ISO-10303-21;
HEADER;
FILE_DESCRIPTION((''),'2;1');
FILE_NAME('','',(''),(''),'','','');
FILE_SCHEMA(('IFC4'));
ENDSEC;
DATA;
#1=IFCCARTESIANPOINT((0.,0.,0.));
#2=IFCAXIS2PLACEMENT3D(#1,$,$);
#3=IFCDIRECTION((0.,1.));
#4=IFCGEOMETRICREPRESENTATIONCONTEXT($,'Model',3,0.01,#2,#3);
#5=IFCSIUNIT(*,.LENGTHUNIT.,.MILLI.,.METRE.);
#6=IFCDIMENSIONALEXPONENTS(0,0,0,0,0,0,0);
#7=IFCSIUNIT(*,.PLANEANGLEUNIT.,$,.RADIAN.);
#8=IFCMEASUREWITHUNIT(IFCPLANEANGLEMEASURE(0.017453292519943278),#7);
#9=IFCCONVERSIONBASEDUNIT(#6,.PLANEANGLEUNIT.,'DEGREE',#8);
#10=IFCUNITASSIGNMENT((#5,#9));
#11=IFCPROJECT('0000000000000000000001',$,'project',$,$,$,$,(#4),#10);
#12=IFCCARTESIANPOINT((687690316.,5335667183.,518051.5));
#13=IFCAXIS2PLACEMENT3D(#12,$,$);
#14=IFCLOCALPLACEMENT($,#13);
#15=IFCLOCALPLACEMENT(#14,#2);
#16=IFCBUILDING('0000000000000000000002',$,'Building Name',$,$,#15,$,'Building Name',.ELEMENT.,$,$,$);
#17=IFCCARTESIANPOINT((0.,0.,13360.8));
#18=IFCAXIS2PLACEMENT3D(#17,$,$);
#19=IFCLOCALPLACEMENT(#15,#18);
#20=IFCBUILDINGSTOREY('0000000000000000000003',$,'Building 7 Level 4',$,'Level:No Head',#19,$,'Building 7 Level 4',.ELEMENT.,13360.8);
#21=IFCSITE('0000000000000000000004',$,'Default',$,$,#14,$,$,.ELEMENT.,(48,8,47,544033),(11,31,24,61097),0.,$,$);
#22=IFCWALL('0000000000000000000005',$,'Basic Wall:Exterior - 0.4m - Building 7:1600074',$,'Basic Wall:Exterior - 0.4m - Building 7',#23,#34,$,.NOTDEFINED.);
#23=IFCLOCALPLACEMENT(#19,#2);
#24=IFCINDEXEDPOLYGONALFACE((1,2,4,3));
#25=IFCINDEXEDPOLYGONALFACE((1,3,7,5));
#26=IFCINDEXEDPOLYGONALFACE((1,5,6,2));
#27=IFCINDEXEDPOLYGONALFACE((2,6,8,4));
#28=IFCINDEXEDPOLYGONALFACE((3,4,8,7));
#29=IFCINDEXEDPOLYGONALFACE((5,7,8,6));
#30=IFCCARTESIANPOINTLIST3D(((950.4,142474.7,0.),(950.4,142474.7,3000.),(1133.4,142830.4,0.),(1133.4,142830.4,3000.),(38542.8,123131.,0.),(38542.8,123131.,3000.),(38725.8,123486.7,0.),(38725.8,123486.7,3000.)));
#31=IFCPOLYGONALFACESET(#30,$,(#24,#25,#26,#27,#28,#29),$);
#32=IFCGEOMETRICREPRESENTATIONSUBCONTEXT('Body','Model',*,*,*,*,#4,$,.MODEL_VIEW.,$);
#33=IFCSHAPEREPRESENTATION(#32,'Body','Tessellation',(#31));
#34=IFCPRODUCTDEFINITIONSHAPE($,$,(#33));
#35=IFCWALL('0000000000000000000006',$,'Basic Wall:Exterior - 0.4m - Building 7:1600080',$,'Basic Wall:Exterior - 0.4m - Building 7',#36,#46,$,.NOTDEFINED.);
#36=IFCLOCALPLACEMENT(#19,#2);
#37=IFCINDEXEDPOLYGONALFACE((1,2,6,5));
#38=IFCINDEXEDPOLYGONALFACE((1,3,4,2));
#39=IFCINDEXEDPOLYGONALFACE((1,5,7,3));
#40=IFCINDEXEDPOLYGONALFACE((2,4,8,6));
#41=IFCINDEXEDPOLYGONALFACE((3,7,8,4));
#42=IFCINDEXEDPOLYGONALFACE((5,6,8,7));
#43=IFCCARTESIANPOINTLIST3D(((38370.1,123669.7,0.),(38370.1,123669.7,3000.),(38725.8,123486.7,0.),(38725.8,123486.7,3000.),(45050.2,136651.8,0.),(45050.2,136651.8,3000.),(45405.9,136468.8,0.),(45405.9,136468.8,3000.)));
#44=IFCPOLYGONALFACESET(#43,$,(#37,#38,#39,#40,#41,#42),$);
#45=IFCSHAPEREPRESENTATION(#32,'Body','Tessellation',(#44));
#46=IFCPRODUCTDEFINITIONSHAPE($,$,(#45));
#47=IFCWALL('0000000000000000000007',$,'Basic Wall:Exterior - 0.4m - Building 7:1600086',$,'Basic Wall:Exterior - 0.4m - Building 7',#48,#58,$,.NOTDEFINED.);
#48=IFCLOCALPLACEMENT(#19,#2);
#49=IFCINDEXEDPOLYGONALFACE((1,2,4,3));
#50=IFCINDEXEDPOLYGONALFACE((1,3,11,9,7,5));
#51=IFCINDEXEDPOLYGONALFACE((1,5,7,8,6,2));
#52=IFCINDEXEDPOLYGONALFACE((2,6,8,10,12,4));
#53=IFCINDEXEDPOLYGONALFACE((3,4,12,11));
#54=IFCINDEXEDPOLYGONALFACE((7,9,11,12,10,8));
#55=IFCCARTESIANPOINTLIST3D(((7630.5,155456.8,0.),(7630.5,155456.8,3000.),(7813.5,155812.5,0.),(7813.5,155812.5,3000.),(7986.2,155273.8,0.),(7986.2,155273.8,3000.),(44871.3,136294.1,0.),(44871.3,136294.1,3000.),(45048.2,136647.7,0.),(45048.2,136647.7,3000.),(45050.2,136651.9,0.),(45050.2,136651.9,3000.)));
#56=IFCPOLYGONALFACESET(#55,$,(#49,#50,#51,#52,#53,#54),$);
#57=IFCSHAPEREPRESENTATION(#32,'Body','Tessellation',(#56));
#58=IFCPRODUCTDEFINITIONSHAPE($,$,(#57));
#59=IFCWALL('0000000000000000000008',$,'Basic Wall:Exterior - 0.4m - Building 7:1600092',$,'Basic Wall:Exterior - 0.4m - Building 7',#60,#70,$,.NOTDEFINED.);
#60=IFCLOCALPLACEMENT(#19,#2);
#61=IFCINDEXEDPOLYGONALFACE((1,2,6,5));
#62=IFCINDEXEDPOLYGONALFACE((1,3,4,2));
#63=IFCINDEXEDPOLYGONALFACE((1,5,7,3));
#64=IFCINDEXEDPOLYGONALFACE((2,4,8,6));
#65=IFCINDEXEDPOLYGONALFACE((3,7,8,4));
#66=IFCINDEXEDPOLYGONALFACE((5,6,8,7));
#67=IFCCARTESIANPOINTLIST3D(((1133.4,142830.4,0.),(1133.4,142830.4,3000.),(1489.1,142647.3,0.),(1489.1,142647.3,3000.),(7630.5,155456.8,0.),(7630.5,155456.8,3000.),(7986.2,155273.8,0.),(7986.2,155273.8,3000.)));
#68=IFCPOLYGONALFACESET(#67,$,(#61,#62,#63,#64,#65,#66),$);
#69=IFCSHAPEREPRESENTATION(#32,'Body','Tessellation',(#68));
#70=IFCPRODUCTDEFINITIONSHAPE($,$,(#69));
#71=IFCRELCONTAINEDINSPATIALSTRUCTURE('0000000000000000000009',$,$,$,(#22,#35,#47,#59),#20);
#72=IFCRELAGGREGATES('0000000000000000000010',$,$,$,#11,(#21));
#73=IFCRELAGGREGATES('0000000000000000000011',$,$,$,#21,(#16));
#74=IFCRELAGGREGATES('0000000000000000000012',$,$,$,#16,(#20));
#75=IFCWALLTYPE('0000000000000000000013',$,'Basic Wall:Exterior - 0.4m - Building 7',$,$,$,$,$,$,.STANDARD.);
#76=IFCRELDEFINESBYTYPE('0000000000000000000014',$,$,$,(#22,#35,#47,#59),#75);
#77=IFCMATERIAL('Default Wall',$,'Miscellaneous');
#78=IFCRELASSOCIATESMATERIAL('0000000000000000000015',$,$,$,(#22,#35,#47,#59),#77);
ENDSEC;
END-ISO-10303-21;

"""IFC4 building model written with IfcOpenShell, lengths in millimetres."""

from ifc_helpers import new_model, entity, si_unit, converted_unit, direction, frame, origin, place, context, subcontext, project, spatial, indexed_curve, outline, extrude, material, type_object, element, save


model = new_model("IFC4")

# Units and contexts
model_context = context("Model", 3, precision=0.01, world=origin(), true_north=direction((0.0, 1.0)))
body_context = subcontext(model_context, "Body", "Model", "MODEL_VIEW")
ifc_project = project(units=[si_unit("LENGTHUNIT", "METRE", prefix="MILLI"), converted_unit("PLANEANGLEUNIT", "DEGREE", entity("IfcPlaneAngleMeasure", 0.017453292519943278), si_unit("PLANEANGLEUNIT", "RADIAN"), dimensions=[0, 0, 0, 0, 0, 0, 0])], contexts=[model_context])

# Site, building, storey
site_placement = place(None, frame((687690316.0, 5335667183.0, 518051.5)))
site = spatial("IfcSite", under=ifc_project, at=site_placement, Name="Default", CompositionType="ELEMENT", RefLatitude=(48, 8, 47, 544033), RefLongitude=(11, 31, 24, 61097), RefElevation=0.0)
building_placement = place(site_placement, origin())
building = spatial("IfcBuilding", under=site, at=building_placement, Name="Building Name", LongName="Building Name", CompositionType="ELEMENT")
storey_placement = place(building_placement, frame((0.0, 0.0, 13360.8)))
storey = spatial("IfcBuildingStorey", under=building, at=storey_placement, Name="Building 7 Level 4", ObjectType="Level:No Head", LongName="Building 7 Level 4", CompositionType="ELEMENT", Elevation=13360.8)

# Walls
ifc_material_1 = material(Name="Default Wall", Category="Miscellaneous")
wall_type = type_object("IfcWallType", Name="Basic Wall:Exterior - 0.4m - Building 7", PredefinedType="STANDARD")
wall_1_placement = place(storey_placement, frame((1041.9, 142652.5, 0.0), z_axis=(0.0, 0.0, 1.0), x_axis=(0.889187, -0.457543, 0.0)))
element("IfcWall", 1, at=wall_1_placement, inside=storey, type_object=wall_type, material=ifc_material_1, Name="Basic Wall:Exterior - 0.4m - Building 7:1600074", ObjectType="Basic Wall:Exterior - 0.4m - Building 7", PredefinedType="NOTDEFINED", context=body_context, shape_type="SweptSolid", body=[
    extrude(outline(indexed_curve([(42277.2, 200.0), (0.0, 200.0), (0.0, -200.0), (42277.2, -200.0), (42277.2, 200.0)], self_intersect=False)), origin(), (0.0, 0.0, 1.0), 3000.0),
])
wall_2_placement = place(storey_placement, frame((38548.0, 123578.2, 0.0), z_axis=(0.0, 0.0, 1.0), x_axis=(0.457543, 0.889187, 0.0)))
element("IfcWall", 2, at=wall_2_placement, inside=storey, type_object=wall_type, material=ifc_material_1, Name="Basic Wall:Exterior - 0.4m - Building 7:1600080", ObjectType="Basic Wall:Exterior - 0.4m - Building 7", PredefinedType="NOTDEFINED", context=body_context, shape_type="SweptSolid", body=[
    extrude(outline(indexed_curve([(14600.0, 200.0), (0.0, 200.0), (0.0, -200.0), (14600.0, -200.0), (14600.0, 200.0)], self_intersect=False)), origin(), (0.0, 0.0, 1.0), 3000.0),
])
wall_3_placement = place(storey_placement, frame((44962.8, 136471.9, 0.0), z_axis=(0.0, 0.0, 1.0), x_axis=(-0.889187, 0.457543, 0.0)))
element("IfcWall", 3, at=wall_3_placement, inside=storey, type_object=wall_type, material=ifc_material_1, Name="Basic Wall:Exterior - 0.4m - Building 7:1600086", ObjectType="Basic Wall:Exterior - 0.4m - Building 7", PredefinedType="NOTDEFINED", context=body_context, shape_type="SweptSolid", body=[
    extrude(outline(indexed_curve([(41881.8, -200.0), (41881.8, 200.0), (41481.8, 200.0), (0.0, 200.0), (4.6, -195.4), (4.6, -200.0), (41881.8, -200.0)], self_intersect=False)), origin(), (0.0, 0.0, 1.0), 3000.0),
])
wall_4_placement = place(storey_placement, frame((7808.3, 155365.3, 0.0), z_axis=(0.0, 0.0, 1.0), x_axis=(-0.457543, -0.889187, 0.0)))
element("IfcWall", 4, at=wall_4_placement, inside=storey, type_object=wall_type, material=ifc_material_1, Name="Basic Wall:Exterior - 0.4m - Building 7:1600092", ObjectType="Basic Wall:Exterior - 0.4m - Building 7", PredefinedType="NOTDEFINED", context=body_context, shape_type="SweptSolid", body=[
    extrude(outline(indexed_curve([(14200.0, 200.0), (0.0, 200.0), (0.0, -200.0), (14200.0, -200.0), (14200.0, 200.0)], self_intersect=False)), origin(), (0.0, 0.0, 1.0), 3000.0),
])

save(model, "model.ifc")
